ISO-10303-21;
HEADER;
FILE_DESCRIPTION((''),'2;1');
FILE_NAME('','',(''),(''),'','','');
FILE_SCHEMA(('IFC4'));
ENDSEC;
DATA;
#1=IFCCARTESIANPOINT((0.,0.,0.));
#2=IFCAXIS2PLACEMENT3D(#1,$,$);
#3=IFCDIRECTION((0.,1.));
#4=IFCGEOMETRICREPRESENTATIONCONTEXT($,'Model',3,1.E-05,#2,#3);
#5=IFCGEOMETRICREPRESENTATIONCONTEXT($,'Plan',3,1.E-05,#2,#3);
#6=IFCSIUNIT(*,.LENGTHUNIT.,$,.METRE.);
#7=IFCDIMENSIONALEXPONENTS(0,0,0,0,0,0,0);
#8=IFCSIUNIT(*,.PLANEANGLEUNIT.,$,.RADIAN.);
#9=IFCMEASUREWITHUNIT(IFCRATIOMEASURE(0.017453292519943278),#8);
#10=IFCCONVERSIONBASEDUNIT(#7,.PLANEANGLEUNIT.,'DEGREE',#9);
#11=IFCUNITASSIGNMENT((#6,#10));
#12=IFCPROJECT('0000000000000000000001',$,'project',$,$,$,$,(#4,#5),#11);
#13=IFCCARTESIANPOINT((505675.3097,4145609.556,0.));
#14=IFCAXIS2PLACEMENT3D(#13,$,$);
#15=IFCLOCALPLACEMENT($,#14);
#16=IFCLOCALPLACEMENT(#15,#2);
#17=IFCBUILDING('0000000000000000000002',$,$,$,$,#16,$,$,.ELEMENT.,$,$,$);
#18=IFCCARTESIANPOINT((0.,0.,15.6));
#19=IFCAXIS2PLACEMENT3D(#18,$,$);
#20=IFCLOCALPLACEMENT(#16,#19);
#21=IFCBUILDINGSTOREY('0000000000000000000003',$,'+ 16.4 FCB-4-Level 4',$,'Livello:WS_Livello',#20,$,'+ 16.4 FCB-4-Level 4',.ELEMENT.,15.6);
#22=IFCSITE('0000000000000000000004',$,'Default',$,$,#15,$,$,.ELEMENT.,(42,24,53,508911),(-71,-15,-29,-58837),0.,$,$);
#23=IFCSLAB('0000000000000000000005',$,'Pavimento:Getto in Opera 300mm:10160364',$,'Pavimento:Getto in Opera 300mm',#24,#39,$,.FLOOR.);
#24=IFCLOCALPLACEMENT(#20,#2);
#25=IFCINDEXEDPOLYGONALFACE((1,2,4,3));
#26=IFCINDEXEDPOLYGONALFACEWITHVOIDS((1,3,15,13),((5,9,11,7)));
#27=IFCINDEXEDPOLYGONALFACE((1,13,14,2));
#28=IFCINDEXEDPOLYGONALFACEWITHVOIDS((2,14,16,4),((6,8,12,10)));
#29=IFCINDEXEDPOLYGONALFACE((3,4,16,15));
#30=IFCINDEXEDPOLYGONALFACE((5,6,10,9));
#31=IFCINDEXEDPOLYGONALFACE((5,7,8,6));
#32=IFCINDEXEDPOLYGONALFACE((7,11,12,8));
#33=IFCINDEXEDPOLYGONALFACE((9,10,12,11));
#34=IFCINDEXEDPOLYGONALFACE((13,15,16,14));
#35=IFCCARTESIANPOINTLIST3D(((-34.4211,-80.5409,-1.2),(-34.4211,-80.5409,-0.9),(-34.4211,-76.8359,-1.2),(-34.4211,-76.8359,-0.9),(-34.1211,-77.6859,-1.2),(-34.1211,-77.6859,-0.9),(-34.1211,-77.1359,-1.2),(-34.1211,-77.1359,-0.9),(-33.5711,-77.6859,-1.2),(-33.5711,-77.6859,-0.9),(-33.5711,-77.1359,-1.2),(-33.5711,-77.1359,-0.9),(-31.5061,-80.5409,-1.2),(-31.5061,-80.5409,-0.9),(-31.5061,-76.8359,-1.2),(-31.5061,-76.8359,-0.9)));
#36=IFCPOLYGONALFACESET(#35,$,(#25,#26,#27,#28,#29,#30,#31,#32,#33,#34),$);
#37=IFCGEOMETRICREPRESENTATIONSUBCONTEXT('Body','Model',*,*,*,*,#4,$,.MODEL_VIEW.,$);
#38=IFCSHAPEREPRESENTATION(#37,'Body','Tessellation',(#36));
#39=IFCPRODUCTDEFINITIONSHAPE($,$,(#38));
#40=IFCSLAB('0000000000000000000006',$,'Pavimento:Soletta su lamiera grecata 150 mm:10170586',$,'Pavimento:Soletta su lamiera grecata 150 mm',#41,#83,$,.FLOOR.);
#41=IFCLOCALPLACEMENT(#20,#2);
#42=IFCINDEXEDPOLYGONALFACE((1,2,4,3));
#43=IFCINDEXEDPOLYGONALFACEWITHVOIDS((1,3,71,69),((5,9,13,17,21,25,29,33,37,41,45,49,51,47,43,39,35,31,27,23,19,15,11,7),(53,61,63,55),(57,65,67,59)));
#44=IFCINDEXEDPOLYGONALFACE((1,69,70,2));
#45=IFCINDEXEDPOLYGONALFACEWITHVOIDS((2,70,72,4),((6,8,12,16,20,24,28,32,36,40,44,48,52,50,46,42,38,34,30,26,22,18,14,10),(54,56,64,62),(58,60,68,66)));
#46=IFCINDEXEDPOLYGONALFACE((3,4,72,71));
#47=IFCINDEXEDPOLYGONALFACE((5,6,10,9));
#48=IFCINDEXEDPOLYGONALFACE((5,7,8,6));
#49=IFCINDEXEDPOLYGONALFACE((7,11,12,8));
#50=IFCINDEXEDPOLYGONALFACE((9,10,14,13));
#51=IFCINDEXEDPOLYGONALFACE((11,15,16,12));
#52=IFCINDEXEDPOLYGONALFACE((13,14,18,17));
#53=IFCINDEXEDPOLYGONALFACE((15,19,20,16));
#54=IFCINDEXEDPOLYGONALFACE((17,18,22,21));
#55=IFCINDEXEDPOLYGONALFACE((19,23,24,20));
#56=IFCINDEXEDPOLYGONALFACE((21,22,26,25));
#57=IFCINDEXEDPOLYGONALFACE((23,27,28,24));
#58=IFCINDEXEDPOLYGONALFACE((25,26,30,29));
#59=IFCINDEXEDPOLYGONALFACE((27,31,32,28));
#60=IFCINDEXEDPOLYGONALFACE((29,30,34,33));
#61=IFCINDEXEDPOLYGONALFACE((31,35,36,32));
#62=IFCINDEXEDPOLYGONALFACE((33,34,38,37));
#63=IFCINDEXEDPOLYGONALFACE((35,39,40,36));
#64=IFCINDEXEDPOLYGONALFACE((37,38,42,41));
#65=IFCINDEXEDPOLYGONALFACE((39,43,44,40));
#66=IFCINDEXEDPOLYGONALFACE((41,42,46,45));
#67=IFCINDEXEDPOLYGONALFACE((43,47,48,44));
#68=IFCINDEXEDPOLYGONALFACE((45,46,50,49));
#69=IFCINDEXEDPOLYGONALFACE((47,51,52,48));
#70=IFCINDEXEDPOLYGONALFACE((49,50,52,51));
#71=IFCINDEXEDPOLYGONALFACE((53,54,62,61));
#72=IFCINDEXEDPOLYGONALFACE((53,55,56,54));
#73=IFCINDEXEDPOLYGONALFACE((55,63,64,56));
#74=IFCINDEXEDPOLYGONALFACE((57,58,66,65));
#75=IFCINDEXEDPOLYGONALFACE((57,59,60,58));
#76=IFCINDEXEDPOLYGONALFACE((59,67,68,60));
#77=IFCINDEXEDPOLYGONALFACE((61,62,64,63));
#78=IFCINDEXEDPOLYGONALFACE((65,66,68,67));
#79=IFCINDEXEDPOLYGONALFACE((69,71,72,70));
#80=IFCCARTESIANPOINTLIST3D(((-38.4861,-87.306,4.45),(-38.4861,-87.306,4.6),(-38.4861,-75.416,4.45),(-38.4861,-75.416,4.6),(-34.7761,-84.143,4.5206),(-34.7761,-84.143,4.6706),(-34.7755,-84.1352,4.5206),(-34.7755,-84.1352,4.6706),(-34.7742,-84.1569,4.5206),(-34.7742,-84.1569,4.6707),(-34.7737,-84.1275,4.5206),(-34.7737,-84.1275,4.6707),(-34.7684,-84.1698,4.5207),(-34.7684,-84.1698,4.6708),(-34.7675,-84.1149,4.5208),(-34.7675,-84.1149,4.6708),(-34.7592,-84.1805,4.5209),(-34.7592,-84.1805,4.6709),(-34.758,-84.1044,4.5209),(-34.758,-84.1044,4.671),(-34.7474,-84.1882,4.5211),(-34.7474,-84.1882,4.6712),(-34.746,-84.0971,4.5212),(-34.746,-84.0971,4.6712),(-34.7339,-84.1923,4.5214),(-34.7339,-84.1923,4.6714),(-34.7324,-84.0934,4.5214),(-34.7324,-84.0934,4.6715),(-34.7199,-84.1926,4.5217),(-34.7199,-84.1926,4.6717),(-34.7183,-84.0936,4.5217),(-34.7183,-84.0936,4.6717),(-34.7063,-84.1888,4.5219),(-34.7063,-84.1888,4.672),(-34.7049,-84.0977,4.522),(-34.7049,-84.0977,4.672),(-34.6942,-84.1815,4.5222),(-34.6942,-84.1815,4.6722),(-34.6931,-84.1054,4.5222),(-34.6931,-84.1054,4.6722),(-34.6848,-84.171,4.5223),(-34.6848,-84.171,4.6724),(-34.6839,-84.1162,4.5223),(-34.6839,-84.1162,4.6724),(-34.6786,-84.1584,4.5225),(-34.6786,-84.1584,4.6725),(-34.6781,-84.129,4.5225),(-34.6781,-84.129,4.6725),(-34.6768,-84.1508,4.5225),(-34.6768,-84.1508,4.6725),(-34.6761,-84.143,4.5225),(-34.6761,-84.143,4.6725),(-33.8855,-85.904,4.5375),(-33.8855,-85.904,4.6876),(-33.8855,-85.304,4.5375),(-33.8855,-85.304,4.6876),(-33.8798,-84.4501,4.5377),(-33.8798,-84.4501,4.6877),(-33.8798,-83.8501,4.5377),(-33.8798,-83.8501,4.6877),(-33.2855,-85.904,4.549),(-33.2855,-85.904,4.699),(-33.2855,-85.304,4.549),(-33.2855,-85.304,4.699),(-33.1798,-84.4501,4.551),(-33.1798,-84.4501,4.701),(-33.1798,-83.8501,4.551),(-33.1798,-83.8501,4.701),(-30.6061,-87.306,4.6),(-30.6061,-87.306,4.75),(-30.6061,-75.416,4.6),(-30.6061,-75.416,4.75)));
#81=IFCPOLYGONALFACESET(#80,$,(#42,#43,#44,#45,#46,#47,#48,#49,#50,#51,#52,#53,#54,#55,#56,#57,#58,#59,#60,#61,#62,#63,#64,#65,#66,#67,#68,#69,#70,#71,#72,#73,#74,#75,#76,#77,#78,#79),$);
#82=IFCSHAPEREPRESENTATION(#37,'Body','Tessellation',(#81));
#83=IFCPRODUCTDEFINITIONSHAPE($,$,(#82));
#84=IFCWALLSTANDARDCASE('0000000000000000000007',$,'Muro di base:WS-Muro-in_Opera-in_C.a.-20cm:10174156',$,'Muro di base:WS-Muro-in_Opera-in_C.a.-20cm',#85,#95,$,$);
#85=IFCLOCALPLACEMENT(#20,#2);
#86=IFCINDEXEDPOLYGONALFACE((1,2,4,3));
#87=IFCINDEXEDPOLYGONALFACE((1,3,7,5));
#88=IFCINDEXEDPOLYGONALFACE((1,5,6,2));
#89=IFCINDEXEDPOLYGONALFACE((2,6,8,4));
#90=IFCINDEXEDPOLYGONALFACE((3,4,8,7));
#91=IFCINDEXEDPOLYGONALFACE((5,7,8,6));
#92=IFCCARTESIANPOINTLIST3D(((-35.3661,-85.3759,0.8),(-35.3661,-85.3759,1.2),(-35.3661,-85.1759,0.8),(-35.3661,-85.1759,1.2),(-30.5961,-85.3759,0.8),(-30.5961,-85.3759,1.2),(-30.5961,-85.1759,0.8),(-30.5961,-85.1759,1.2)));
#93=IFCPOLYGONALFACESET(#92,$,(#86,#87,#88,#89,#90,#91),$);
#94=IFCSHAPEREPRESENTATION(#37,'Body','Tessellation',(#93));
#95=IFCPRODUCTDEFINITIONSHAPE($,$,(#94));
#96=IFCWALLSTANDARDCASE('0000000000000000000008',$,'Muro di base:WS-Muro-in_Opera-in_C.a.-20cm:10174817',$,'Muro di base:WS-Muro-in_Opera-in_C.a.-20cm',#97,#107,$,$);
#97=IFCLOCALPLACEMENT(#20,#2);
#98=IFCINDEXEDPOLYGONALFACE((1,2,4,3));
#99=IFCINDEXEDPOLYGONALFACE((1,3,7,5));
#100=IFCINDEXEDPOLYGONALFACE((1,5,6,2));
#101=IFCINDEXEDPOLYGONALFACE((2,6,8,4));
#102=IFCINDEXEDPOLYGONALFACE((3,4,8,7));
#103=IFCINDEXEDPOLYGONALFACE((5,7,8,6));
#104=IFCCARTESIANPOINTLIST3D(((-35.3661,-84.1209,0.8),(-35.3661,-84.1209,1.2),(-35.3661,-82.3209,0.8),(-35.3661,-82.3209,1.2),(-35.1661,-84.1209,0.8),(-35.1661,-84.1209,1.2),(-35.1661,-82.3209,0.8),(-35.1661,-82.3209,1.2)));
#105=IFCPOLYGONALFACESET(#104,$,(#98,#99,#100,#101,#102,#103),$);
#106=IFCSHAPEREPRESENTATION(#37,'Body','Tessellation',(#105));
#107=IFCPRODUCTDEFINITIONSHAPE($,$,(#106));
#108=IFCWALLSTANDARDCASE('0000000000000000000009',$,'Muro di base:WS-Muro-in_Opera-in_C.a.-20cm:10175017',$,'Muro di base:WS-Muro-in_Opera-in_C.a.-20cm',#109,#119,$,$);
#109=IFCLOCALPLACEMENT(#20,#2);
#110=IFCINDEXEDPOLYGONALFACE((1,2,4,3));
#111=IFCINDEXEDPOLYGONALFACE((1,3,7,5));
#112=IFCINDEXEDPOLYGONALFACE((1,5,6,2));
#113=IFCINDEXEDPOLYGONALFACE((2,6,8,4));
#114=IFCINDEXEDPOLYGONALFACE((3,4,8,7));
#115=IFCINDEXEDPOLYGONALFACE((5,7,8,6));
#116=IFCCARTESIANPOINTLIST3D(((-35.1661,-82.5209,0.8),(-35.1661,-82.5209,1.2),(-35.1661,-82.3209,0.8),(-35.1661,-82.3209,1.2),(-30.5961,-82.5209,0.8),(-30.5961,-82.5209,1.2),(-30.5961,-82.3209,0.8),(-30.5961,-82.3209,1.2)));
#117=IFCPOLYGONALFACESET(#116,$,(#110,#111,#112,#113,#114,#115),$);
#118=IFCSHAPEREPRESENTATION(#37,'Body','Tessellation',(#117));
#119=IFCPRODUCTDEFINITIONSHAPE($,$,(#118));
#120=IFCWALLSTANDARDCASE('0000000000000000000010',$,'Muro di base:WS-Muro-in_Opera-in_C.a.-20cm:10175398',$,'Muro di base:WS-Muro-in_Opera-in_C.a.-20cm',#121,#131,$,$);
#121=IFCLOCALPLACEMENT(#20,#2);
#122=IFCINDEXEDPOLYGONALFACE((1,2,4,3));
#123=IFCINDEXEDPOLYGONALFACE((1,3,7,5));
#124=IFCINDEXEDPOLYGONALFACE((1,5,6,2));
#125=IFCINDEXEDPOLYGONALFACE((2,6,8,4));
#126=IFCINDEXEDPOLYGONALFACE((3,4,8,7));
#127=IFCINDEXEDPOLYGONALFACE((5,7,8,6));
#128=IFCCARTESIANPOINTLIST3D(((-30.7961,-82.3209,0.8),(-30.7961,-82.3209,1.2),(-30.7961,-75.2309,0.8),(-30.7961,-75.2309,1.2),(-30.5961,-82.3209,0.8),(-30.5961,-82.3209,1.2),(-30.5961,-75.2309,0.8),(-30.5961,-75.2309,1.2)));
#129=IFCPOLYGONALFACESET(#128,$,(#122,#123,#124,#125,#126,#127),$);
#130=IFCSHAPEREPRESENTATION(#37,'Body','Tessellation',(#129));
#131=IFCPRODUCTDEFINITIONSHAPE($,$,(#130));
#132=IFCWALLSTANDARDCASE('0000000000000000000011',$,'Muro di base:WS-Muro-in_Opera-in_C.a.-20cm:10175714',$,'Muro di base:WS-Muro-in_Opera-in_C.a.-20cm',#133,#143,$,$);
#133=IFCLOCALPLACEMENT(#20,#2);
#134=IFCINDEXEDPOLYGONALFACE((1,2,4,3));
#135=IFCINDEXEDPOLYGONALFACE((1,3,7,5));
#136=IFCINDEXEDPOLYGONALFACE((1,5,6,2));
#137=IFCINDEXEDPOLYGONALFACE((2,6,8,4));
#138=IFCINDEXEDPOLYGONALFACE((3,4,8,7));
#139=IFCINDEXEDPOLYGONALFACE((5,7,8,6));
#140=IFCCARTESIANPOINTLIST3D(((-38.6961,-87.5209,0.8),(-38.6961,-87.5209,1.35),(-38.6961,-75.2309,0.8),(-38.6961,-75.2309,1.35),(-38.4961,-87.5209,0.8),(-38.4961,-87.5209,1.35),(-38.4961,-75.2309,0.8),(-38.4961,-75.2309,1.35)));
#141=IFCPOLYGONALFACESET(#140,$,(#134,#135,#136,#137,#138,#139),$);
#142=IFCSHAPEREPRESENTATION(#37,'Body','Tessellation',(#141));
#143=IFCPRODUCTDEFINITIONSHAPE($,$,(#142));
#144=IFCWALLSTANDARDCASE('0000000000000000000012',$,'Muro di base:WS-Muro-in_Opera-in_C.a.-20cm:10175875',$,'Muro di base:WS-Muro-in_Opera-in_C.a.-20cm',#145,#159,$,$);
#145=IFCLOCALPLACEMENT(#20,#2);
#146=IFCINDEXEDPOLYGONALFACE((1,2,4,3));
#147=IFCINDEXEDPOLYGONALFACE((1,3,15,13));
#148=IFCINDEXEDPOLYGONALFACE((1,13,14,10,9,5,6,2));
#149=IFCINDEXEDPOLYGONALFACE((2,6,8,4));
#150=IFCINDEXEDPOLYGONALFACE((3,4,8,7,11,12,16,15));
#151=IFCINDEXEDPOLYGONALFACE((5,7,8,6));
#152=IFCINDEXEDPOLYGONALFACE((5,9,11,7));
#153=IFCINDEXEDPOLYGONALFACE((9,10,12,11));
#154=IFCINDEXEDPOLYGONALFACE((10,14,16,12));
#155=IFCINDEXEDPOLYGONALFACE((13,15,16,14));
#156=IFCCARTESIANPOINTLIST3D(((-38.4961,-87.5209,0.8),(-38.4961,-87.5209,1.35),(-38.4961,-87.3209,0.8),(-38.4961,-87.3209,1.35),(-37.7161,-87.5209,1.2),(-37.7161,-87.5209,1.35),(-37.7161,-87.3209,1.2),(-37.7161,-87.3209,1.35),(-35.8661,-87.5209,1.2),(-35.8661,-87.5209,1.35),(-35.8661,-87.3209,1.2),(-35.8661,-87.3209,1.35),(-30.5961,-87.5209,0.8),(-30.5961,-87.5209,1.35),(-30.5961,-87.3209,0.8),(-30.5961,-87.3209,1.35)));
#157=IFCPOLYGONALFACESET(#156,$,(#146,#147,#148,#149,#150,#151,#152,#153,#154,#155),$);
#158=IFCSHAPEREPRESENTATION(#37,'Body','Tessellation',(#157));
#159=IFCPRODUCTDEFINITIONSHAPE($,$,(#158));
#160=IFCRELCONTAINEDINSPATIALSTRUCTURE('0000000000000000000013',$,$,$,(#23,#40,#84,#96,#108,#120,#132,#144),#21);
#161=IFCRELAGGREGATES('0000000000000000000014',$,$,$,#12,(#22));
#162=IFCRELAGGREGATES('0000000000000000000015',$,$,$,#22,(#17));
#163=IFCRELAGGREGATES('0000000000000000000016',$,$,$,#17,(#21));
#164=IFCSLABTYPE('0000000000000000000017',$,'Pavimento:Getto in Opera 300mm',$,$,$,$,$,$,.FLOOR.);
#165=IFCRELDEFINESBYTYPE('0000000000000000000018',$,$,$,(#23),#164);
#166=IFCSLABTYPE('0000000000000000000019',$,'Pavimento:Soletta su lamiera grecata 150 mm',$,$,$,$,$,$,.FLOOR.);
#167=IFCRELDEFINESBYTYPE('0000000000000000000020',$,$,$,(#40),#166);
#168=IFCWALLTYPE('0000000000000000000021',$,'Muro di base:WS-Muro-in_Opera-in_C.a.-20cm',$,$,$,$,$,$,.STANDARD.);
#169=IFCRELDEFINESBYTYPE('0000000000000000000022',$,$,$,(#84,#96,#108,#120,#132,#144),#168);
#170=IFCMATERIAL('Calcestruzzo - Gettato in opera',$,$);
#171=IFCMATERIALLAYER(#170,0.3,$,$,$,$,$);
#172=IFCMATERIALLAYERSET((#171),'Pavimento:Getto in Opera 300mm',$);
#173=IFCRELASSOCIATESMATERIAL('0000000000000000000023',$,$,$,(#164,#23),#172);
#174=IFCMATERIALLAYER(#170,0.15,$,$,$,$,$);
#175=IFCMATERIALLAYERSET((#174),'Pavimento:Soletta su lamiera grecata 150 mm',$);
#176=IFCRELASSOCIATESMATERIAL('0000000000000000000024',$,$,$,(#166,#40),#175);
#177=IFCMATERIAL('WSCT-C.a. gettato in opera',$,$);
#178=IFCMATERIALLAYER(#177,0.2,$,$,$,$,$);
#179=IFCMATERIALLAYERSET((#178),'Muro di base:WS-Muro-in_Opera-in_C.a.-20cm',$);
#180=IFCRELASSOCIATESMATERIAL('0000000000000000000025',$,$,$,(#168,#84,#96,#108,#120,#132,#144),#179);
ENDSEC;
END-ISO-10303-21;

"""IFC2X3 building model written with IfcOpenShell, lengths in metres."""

from ifc_helpers import new_model, entity, si_unit, converted_unit, direction, frame, frame_2d, origin, origin_2d_with_axis, place, context, subcontext, project, spatial, polyline, ellipse_curve, parameter, trimmed, segment, composite_curve, rectangle, outline, extrude, clip, bounded_halfspace, material, layer, layer_set, layer_usage, type_object, element, save


model = new_model("IFC2X3")

# Units and contexts
model_context = context("Model", 3, precision=1e-05, world=origin(), true_north=direction((0.0, 1.0)))
plan_context = context("Plan", 3, precision=1e-05, world=origin(), true_north=direction((0.0, 1.0)))
body_context = subcontext(model_context, "Body", "Model", "MODEL_VIEW")
ifc_project = project(units=[si_unit("LENGTHUNIT", "METRE"), converted_unit("PLANEANGLEUNIT", "DEGREE", entity("IfcRatioMeasure", 0.017453292519943278), si_unit("PLANEANGLEUNIT", "RADIAN"), dimensions=[0, 0, 0, 0, 0, 0, 0])], contexts=[model_context, plan_context])

# Site, building, storey
site_placement = place(None, frame((505675.3097, 4145609.556, 0.0)))
site = spatial("IfcSite", under=ifc_project, at=site_placement, Name="Default", CompositionType="ELEMENT", RefLatitude=(42, 24, 53, 508911), RefLongitude=(-71, -15, -29, -58837), RefElevation=0.0)
building_placement = place(site_placement, origin())
building = spatial("IfcBuilding", under=site, at=building_placement, CompositionType="ELEMENT")
storey_placement = place(building_placement, frame((0.0, 0.0, 15.6)))
storey = spatial("IfcBuildingStorey", under=building, at=storey_placement, Name="+ 16.4 FCB-4-Level 4", ObjectType="Livello:WS_Livello", LongName="+ 16.4 FCB-4-Level 4", CompositionType="ELEMENT", Elevation=15.6)

# Shared definitions
ifc_material_1 = material(Name="Calcestruzzo - Gettato in opera")

# Slab, opening
ifc_layer_1 = layer(ifc_material_1, 0.3)
ifc_layer_set_1 = layer_set([ifc_layer_1], Name="Pavimento:Getto in Opera 300mm")
ifc_layer_usage_1 = layer_usage(ifc_layer_set_1, "AXIS3", "POSITIVE", 0.0)
slab_type_1 = type_object("IfcSlabType", Name="Pavimento:Getto in Opera 300mm", PredefinedType="FLOOR", material=ifc_layer_set_1)
slab_1_placement = place(storey_placement, frame((-34.4211, -80.5409, -1.2)))
slab_1 = element("IfcSlab", 1, at=slab_1_placement, inside=storey, type_object=slab_type_1, material=ifc_layer_usage_1, Name="Pavimento:Getto in Opera 300mm:10160364", ObjectType="Pavimento:Getto in Opera 300mm", PredefinedType="FLOOR", context=body_context, shape_type="SweptSolid", body=[
    extrude(rectangle(XDim=3.705, YDim=2.915, at=frame_2d((0.0, 0.0), x_axis=(0.0, -1.0))), frame((1.4575, 1.8525, 0.3), z_axis=(0.0, 0.0, -1.0), x_axis=(-1.0, 0.0, 0.0)), (0.0, 0.0, 1.0), 0.3),
])
opening_1_placement = place(slab_1_placement, origin())
element("IfcOpeningElement", 2, at=opening_1_placement, cuts=slab_1, ObjectType="Opening", context=body_context, shape_type="SweptSolid", body=[
    extrude(rectangle(XDim=0.55, YDim=0.55, at=frame_2d((0.0, 0.0), x_axis=(1.0, 0.0))), frame((0.575, 3.13, 0.0), z_axis=(0.0, 0.0, 1.0), x_axis=(-1.0, 0.0, 0.0)), (0.0, 0.0, 1.0), 0.3),
])

# Slab, openings
ifc_layer_2 = layer(ifc_material_1, 0.15)
ifc_layer_set_2 = layer_set([ifc_layer_2], Name="Pavimento:Soletta su lamiera grecata 150 mm")
ifc_layer_usage_2 = layer_usage(ifc_layer_set_2, "AXIS3", "POSITIVE", 0.0)
slab_type_2 = type_object("IfcSlabType", Name="Pavimento:Soletta su lamiera grecata 150 mm", PredefinedType="FLOOR", material=ifc_layer_set_2)
slab_2_placement = place(storey_placement, frame((-38.4861, -87.306, 4.45)))
slab_2 = element("IfcSlab", 3, at=slab_2_placement, inside=storey, type_object=slab_type_2, material=ifc_layer_usage_2, Name="Pavimento:Soletta su lamiera grecata 150 mm:10170586", ObjectType="Pavimento:Soletta su lamiera grecata 150 mm", PredefinedType="FLOOR", context=body_context, shape_type="SweptSolid", body=[
    extrude(rectangle(XDim=11.89, YDim=7.8814, at=frame_2d((3.9407, 5.937), x_axis=(0.0, -1.0))), frame((0.0, 0.008, 0.15), z_axis=(-0.019032, 0.0, 0.999819), x_axis=(0.999819, 0.0, 0.019032)), (-0.019032, 0.0, -0.999819), 0.15),
])
opening_2_placement = place(slab_2_placement, origin())
element("IfcOpeningElement", 4, at=opening_2_placement, cuts=slab_2, ObjectType="Opening", context=body_context, shape_type="SweptSolid", body=[
    extrude(outline(composite_curve([segment(trimmed(ellipse_curve(origin_2d_with_axis(), 0.05, 0.05), [parameter(180.0)], [parameter(360.0)], True, "PARAMETER"), True, "CONTINUOUS"), segment(trimmed(ellipse_curve(origin_2d_with_axis(), 0.05, 0.05), [parameter(360.0)], [parameter(180.0)], True, "PARAMETER"), True, "CONTINUOUS")], self_intersect=False)), frame((3.76, 3.163, 0.0716), z_axis=(-0.019032, 0.0, 0.999819), x_axis=(0.999819, 0.0, 0.019032)), (0.019032, 0.0, 0.999819), 0.15),
])
opening_3_placement = place(slab_2_placement, origin())
element("IfcOpeningElement", 5, at=opening_3_placement, cuts=slab_2, ObjectType="Opening", context=body_context, shape_type="SweptSolid", body=[
    extrude(rectangle(XDim=0.7001, YDim=0.6, at=frame_2d((0.0, 0.0), x_axis=(1.0, 0.0))), frame((4.9563, 3.1559, 0.0943), z_axis=(-0.019032, 0.0, 0.999819), x_axis=(-0.999819, 0.0, -0.019032)), (-0.019032, 0.0, 0.999819), 0.15),
])
opening_4_placement = place(slab_2_placement, origin())
element("IfcOpeningElement", 6, at=opening_4_placement, cuts=slab_2, ObjectType="Opening", context=body_context, shape_type="SweptSolid", body=[
    extrude(rectangle(XDim=0.6001, YDim=0.6, at=frame_2d((0.0, 0.0), x_axis=(1.0, 0.0))), frame((4.9006, 1.702, 0.0933), z_axis=(-0.019032, 0.0, 0.999819), x_axis=(-0.999819, 0.0, -0.019032)), (-0.019032, 0.0, 0.999819), 0.15),
])

# Walls
ifc_material_2 = material(Name="WSCT-C.a. gettato in opera")
ifc_layer_3 = layer(ifc_material_2, 0.2)
ifc_layer_set_3 = layer_set([ifc_layer_3], Name="Muro di base:WS-Muro-in_Opera-in_C.a.-20cm")
ifc_layer_usage_3 = layer_usage(ifc_layer_set_3, "AXIS2", "NEGATIVE", 0.1)
wall_type = type_object("IfcWallType", Name="Muro di base:WS-Muro-in_Opera-in_C.a.-20cm", PredefinedType="STANDARD", material=ifc_layer_set_3)
wall_1_placement = place(storey_placement, frame((-30.5961, -85.2759, 0.8), z_axis=(0.0, 0.0, 1.0), x_axis=(-1.0, 0.0, 0.0)))
element("IfcWallStandardCase", 7, at=wall_1_placement, inside=storey, type_object=wall_type, material=ifc_layer_usage_3, Name="Muro di base:WS-Muro-in_Opera-in_C.a.-20cm:10174156", ObjectType="Muro di base:WS-Muro-in_Opera-in_C.a.-20cm", context=body_context, shape_type="Clipping", body=[
    clip(extrude(rectangle(XDim=4.77, YDim=0.2, at=frame_2d((2.385, 0.0), x_axis=(-1.0, 0.0))), origin(), (0.0, 0.0, 1.0), 0.4), bounded_halfspace(frame((4.77, -0.1, 0.0), z_axis=(0.0, 0.0, 1.0), x_axis=(0.0, -1.0, 0.0)), True, frame((4.77, -0.1, 0.0)), polyline([(0.0, 0.0), (0.0, 0.2), (-4.57, 0.2), (-4.77, 0.2), (-4.77, 0.0), (-0.2, 0.0), (0.0, 0.0)]))),
])
wall_2_placement = place(storey_placement, frame((-35.2661, -84.1209, 0.8), z_axis=(0.0, 0.0, 1.0), x_axis=(0.0, 1.0, 0.0)))
element("IfcWallStandardCase", 8, at=wall_2_placement, inside=storey, type_object=wall_type, material=ifc_layer_usage_3, Name="Muro di base:WS-Muro-in_Opera-in_C.a.-20cm:10174817", ObjectType="Muro di base:WS-Muro-in_Opera-in_C.a.-20cm", context=body_context, shape_type="Clipping", body=[
    clip(extrude(rectangle(XDim=1.8, YDim=0.2, at=frame_2d((0.9, 0.0), x_axis=(-1.0, 0.0))), origin(), (0.0, 0.0, 1.0), 0.4), bounded_halfspace(frame((1.8, -0.1, 0.0)), True, frame((1.8, -0.1, 0.0)), polyline([(0.0, 0.0), (0.0, 0.2), (-1.8, 0.2), (-1.8, 0.0), (-0.2, 0.0), (0.0, 0.0)]))),
])
wall_3_placement = place(storey_placement, frame((-35.1661, -82.4209, 0.8)))
element("IfcWallStandardCase", 9, at=wall_3_placement, inside=storey, type_object=wall_type, material=ifc_layer_usage_3, Name="Muro di base:WS-Muro-in_Opera-in_C.a.-20cm:10175017", ObjectType="Muro di base:WS-Muro-in_Opera-in_C.a.-20cm", context=body_context, shape_type="Clipping", body=[
    clip(extrude(rectangle(XDim=4.57, YDim=0.2, at=frame_2d((2.285, 0.0), x_axis=(-1.0, 0.0))), origin(), (0.0, 0.0, 1.0), 0.4), bounded_halfspace(frame((4.57, -0.1, 0.0), z_axis=(0.0, 0.0, 1.0), x_axis=(0.0, 1.0, 0.0)), True, frame((4.57, -0.1, 0.0)), polyline([(0.0, 0.0), (0.0, 0.2), (-0.2, 0.2), (-4.57, 0.2), (-4.57, 0.0), (0.0, 0.0)]))),
])
wall_4_placement = place(storey_placement, frame((-30.6961, -82.3209, 0.8), z_axis=(0.0, 0.0, 1.0), x_axis=(0.0, 1.0, 0.0)))
element("IfcWallStandardCase", 10, at=wall_4_placement, inside=storey, type_object=wall_type, material=ifc_layer_usage_3, Name="Muro di base:WS-Muro-in_Opera-in_C.a.-20cm:10175398", ObjectType="Muro di base:WS-Muro-in_Opera-in_C.a.-20cm", context=body_context, shape_type="Clipping", body=[
    clip(extrude(rectangle(XDim=7.09, YDim=0.2, at=frame_2d((3.545, 0.0), x_axis=(-1.0, 0.0))), origin(), (0.0, 0.0, 1.0), 0.4), bounded_halfspace(frame((7.09, -0.1, 0.0)), True, frame((7.09, -0.1, 0.0)), polyline([(0.0, 0.0), (0.0, 0.2), (-0.2, 0.2), (-7.09, 0.2), (-7.09, 0.0), (0.0, 0.0)]))),
])
wall_5_placement = place(storey_placement, frame((-38.5961, -75.2309, 0.8), z_axis=(0.0, 0.0, 1.0), x_axis=(0.0, -1.0, 0.0)))
element("IfcWallStandardCase", 11, at=wall_5_placement, inside=storey, type_object=wall_type, material=ifc_layer_usage_3, Name="Muro di base:WS-Muro-in_Opera-in_C.a.-20cm:10175714", ObjectType="Muro di base:WS-Muro-in_Opera-in_C.a.-20cm", context=body_context, shape_type="Clipping", body=[
    clip(extrude(rectangle(XDim=12.29, YDim=0.2, at=frame_2d((6.145, 0.0), x_axis=(-1.0, 0.0))), origin(), (0.0, 0.0, 1.0), 0.55), bounded_halfspace(frame((12.29, -0.1, 0.0), z_axis=(0.0, 0.0, 1.0), x_axis=(-1.0, 0.0, 0.0)), True, frame((12.29, -0.1, 0.0)), polyline([(0.0, 0.0), (0.0, 0.2), (-0.2, 0.2), (-12.09, 0.2), (-12.29, 0.2), (-12.29, 0.0), (0.0, 0.0)]))),
])

# Wall, opening
wall_6_placement = place(storey_placement, frame((-38.4961, -87.4209, 0.8)))
wall_6 = element("IfcWallStandardCase", 12, at=wall_6_placement, inside=storey, type_object=wall_type, material=ifc_layer_usage_3, Name="Muro di base:WS-Muro-in_Opera-in_C.a.-20cm:10175875", ObjectType="Muro di base:WS-Muro-in_Opera-in_C.a.-20cm", context=body_context, shape_type="Clipping", body=[
    clip(extrude(rectangle(XDim=7.9, YDim=0.2, at=frame_2d((3.95, 0.0), x_axis=(-1.0, 0.0))), origin(), (0.0, 0.0, 1.0), 0.55), bounded_halfspace(frame((7.9, -0.1, 0.0), z_axis=(0.0, 0.0, 1.0), x_axis=(0.0, 1.0, 0.0)), True, frame((7.9, -0.1, 0.0)), polyline([(0.0, 0.0), (0.0, 0.2), (-0.2, 0.2), (-7.9, 0.2), (-7.9, 0.0), (0.0, 0.0)]))),
])
opening_5_placement = place(wall_6_placement, origin())
element("IfcOpeningElement", 13, at=opening_5_placement, cuts=wall_6, ObjectType="Opening", context=body_context, shape_type="SweptSolid", body=[
    extrude(rectangle(XDim=0.15, YDim=1.85, at=frame_2d((0.0, 0.0), x_axis=(0.0, 1.0))), frame((1.705, 0.1, 0.475), z_axis=(0.0, -1.0, 0.0), x_axis=(-1.0, 0.0, 0.0)), (0.0, 0.0, 1.0), 0.2),
])

save(model, "model.ifc")
